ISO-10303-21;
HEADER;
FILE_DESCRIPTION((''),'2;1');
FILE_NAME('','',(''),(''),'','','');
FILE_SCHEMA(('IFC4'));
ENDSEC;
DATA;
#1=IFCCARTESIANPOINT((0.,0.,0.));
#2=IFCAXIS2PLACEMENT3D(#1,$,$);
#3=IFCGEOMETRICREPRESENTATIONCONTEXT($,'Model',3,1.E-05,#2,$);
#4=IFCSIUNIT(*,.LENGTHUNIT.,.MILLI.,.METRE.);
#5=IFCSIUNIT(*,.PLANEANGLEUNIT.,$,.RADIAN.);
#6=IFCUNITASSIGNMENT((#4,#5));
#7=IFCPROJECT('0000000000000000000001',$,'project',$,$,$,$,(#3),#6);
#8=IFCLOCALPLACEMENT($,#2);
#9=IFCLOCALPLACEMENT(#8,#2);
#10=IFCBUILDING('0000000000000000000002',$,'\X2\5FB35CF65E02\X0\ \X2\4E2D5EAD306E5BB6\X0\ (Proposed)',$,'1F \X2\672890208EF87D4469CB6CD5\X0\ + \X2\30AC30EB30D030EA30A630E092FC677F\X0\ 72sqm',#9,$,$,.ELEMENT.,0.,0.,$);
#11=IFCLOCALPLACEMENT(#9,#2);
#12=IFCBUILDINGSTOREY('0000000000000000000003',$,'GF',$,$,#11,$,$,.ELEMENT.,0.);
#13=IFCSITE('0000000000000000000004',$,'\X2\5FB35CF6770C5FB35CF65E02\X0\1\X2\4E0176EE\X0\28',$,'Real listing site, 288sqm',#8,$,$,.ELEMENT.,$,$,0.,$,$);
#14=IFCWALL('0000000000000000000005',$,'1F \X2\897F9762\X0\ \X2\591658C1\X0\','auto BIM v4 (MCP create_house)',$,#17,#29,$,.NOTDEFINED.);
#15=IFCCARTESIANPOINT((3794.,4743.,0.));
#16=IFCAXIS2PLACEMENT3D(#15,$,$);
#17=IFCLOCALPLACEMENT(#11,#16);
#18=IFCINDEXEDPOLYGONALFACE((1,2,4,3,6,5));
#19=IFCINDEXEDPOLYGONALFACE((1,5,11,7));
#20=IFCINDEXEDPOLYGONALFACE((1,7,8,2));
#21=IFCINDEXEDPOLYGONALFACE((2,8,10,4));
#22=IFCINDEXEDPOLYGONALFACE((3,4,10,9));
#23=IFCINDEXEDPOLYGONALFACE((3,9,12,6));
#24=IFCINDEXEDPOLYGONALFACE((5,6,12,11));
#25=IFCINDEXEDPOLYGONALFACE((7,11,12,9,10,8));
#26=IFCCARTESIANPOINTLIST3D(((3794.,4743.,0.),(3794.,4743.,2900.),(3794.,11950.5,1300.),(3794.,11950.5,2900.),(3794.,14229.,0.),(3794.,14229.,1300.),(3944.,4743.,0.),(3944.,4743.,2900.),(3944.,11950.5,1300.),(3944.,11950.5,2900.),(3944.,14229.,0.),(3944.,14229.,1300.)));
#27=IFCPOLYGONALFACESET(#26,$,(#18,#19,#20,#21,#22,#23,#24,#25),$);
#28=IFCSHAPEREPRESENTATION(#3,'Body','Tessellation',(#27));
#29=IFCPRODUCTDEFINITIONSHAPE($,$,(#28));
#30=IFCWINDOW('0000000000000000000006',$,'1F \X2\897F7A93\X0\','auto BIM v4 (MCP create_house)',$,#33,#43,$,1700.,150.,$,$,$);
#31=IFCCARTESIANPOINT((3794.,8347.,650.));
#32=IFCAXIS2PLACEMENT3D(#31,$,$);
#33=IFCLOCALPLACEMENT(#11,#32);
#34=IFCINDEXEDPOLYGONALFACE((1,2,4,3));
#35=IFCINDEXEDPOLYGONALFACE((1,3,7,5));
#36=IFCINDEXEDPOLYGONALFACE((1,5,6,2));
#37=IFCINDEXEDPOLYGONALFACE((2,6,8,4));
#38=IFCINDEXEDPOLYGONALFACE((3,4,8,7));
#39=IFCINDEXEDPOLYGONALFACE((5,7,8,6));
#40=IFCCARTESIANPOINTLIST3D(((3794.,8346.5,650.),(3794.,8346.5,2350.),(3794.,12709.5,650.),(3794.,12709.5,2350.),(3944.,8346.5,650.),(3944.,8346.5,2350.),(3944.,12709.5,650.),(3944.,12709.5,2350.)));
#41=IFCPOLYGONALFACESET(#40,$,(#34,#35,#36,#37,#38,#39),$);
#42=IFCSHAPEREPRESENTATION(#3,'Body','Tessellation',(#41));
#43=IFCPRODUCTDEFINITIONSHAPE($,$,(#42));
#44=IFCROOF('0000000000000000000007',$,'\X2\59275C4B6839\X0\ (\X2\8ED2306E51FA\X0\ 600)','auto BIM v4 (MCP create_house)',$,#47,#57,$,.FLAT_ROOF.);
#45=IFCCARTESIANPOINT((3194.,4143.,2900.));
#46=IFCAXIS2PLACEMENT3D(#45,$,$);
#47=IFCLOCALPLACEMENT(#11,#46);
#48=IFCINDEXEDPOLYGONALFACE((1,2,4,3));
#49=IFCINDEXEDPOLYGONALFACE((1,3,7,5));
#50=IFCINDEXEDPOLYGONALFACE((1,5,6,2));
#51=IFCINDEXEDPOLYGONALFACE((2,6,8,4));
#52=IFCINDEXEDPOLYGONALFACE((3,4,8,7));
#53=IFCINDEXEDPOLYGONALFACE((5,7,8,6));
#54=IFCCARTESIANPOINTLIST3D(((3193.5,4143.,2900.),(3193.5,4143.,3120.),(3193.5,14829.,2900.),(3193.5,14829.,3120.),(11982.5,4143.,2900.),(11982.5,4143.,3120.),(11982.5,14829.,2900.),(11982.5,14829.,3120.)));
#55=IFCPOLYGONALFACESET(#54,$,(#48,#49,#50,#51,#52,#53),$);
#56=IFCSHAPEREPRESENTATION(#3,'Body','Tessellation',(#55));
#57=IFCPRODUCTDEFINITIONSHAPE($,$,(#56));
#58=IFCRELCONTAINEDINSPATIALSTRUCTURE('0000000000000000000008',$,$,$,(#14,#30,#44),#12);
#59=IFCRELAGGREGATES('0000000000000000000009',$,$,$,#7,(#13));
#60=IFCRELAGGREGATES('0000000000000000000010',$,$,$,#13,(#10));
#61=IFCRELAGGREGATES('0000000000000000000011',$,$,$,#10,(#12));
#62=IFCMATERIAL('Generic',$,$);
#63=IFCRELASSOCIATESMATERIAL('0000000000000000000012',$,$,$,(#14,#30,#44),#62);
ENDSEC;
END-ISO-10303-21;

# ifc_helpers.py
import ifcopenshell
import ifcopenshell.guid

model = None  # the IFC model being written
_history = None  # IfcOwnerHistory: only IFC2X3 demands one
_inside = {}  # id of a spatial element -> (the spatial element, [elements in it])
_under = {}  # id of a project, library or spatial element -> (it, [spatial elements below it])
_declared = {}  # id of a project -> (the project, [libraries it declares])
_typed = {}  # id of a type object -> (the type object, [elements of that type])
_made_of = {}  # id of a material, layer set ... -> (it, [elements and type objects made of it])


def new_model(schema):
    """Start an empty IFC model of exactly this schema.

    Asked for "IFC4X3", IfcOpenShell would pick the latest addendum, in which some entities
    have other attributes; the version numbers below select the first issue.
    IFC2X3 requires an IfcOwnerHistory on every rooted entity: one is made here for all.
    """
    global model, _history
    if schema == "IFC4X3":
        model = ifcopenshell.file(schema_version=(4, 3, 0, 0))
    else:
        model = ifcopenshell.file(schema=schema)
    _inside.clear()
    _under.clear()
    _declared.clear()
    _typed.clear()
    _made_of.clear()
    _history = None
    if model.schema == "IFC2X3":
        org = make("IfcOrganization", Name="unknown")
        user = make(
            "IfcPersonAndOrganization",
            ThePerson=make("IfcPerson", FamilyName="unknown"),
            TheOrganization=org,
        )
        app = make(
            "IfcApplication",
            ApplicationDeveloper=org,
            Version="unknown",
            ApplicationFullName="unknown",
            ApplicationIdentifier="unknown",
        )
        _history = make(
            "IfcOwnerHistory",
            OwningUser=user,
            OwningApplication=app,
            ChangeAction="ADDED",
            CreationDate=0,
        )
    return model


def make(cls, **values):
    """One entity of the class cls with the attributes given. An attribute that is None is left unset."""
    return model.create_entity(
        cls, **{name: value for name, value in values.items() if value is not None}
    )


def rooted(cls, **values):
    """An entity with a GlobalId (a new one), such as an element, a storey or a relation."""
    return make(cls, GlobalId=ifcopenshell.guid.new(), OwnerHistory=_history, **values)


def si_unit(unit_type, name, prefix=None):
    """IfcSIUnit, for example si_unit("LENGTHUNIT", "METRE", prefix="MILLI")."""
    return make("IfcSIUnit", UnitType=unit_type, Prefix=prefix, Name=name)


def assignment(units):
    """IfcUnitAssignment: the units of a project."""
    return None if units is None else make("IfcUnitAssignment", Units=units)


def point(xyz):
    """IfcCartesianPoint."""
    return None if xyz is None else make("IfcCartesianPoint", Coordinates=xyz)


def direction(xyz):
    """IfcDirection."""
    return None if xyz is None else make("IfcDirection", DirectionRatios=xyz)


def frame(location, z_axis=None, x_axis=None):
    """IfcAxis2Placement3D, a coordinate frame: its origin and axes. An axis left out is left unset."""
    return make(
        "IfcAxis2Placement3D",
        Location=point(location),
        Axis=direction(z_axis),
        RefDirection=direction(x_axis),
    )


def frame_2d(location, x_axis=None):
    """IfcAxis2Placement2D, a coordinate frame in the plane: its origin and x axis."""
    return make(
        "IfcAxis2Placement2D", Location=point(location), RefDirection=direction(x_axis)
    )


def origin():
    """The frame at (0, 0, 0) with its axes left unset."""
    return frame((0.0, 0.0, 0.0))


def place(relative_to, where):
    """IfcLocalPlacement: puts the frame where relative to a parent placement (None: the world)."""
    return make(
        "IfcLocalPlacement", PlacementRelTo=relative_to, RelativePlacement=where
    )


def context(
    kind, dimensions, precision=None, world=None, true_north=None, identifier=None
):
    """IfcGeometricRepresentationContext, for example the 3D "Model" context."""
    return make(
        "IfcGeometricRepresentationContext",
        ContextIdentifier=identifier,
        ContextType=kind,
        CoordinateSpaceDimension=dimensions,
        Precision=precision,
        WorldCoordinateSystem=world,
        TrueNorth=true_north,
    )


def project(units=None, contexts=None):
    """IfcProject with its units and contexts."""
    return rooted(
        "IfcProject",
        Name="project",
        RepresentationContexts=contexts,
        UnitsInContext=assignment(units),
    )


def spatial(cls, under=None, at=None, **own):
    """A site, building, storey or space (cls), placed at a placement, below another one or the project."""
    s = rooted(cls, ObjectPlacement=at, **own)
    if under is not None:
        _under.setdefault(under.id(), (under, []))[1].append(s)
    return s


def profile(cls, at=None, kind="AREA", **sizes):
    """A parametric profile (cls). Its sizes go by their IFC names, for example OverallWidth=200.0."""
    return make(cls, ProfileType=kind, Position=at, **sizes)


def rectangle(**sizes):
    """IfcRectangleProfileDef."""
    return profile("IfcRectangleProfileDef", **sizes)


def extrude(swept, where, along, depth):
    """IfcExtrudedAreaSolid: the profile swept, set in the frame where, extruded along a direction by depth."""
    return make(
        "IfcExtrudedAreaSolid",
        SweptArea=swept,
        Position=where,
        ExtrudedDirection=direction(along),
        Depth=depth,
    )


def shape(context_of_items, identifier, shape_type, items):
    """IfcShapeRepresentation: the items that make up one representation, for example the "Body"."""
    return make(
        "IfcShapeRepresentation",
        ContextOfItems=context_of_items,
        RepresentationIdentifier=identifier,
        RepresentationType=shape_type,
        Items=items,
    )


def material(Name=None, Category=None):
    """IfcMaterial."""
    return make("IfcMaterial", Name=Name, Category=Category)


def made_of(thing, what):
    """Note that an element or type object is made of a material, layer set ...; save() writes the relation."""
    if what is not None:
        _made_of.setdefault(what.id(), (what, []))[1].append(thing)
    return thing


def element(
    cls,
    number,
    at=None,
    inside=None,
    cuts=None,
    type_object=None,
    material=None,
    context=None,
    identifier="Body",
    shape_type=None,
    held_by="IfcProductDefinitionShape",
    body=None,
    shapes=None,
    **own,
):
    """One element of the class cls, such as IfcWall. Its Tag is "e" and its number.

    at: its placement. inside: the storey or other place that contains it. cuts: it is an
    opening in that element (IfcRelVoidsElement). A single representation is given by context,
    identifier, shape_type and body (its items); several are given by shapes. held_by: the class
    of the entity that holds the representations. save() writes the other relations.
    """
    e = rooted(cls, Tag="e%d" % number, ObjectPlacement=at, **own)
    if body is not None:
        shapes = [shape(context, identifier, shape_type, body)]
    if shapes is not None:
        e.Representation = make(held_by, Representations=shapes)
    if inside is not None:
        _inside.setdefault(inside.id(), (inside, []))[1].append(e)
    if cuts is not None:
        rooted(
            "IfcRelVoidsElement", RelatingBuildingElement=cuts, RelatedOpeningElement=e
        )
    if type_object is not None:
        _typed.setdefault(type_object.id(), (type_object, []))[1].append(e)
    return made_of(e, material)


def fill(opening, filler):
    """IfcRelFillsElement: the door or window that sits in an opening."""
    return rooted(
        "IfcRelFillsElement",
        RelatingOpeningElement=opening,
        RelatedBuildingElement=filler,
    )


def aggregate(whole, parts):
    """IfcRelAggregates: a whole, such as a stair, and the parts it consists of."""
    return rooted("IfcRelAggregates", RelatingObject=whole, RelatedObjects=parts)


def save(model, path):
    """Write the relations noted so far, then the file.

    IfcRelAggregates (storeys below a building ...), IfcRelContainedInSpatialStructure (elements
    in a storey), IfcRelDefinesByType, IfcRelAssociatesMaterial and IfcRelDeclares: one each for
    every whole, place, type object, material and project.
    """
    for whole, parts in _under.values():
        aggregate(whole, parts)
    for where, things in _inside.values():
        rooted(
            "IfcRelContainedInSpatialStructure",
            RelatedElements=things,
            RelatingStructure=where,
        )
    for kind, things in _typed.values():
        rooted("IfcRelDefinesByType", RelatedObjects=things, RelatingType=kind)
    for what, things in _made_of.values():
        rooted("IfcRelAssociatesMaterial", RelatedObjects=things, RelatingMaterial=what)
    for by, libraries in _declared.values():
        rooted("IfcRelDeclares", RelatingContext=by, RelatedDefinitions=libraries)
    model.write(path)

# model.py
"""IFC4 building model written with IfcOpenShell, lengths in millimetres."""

from ifc_helpers import new_model, si_unit, frame, frame_2d, origin, place, context, project, spatial, rectangle, extrude, material, element, fill, save


model = new_model("IFC4")

# Units and contexts
model_context = context("Model", 3, precision=1e-05, world=origin())
ifc_project = project(units=[si_unit("LENGTHUNIT", "METRE", prefix="MILLI"), si_unit("PLANEANGLEUNIT", "RADIAN")], contexts=[model_context])

# Site, building, storey
site_placement = place(None, origin())
site = spatial("IfcSite", under=ifc_project, at=site_placement, Name="徳島県徳島市1丁目28", ObjectType="Real listing site, 288sqm", CompositionType="ELEMENT", RefElevation=0.0)
building_placement = place(site_placement, origin())
building = spatial("IfcBuilding", under=site, at=building_placement, Name="徳島市 中庭の家 (Proposed)", ObjectType="1F 木造軸組構法 + ガルバリウム鋼板 72sqm", CompositionType="ELEMENT", ElevationOfRefHeight=0.0, ElevationOfTerrain=0.0)
storey_placement = place(building_placement, origin())
storey = spatial("IfcBuildingStorey", under=building, at=storey_placement, Name="GF", CompositionType="ELEMENT", Elevation=0.0)

# Shared definitions
ifc_material = material(Name="Generic")

# Wall, opening, window
wall_1_placement = place(storey_placement, frame((3794.0, 4743.0, 0.0)))
wall_1 = element("IfcWall", 1, at=wall_1_placement, inside=storey, material=ifc_material, Name="1F 西面 外壁", Description="auto BIM v4 (MCP create_house)", PredefinedType="NOTDEFINED", context=model_context, shape_type="SweptSolid", body=[
    extrude(rectangle(XDim=150.0, YDim=9486.0, at=frame_2d((75.0, 4743.0))), frame((3794.0, 4743.0, 0.0)), (0.0, 0.0, 1.0), 2900.0),
])
opening_1_placement = place(storey_placement, frame((3794.0, 8347.0, 650.0)))
opening_1 = element("IfcOpeningElement", 2, at=opening_1_placement, cuts=wall_1, PredefinedType="NOTDEFINED", context=model_context, shape_type="SweptSolid", body=[
    extrude(rectangle(XDim=150.0, YDim=4363.0, at=frame_2d((75.0, 2181.0))), frame((3794.0, 8347.0, 650.0)), (0.0, 0.0, 1.0), 1700.0),
])
window_1_placement = place(storey_placement, frame((3794.0, 8347.0, 650.0)))
window_1 = element("IfcWindow", 3, at=window_1_placement, inside=storey, material=ifc_material, Name="1F 西窓", Description="auto BIM v4 (MCP create_house)", OverallHeight=1700.0, OverallWidth=150.0, context=model_context, shape_type="SweptSolid", body=[
    extrude(rectangle(XDim=150.0, YDim=4363.0, at=frame_2d((75.0, 2181.0))), frame((3794.0, 8347.0, 650.0)), (0.0, 0.0, 1.0), 1700.0),
])
fill(opening_1, window_1)

# Roof
roof_placement = place(storey_placement, frame((3194.0, 4143.0, 2900.0)))
element("IfcRoof", 4, at=roof_placement, inside=storey, material=ifc_material, Name="大屋根 (軒の出 600)", Description="auto BIM v4 (MCP create_house)", PredefinedType="FLAT_ROOF", context=model_context, shape_type="SweptSolid", body=[
    extrude(rectangle(XDim=8789.0, YDim=10686.0, at=frame_2d((4394.0, 5343.0))), frame((3194.0, 4143.0, 2900.0)), (0.0, 0.0, 1.0), 220.0),
])

save(model, "model.ifc")
